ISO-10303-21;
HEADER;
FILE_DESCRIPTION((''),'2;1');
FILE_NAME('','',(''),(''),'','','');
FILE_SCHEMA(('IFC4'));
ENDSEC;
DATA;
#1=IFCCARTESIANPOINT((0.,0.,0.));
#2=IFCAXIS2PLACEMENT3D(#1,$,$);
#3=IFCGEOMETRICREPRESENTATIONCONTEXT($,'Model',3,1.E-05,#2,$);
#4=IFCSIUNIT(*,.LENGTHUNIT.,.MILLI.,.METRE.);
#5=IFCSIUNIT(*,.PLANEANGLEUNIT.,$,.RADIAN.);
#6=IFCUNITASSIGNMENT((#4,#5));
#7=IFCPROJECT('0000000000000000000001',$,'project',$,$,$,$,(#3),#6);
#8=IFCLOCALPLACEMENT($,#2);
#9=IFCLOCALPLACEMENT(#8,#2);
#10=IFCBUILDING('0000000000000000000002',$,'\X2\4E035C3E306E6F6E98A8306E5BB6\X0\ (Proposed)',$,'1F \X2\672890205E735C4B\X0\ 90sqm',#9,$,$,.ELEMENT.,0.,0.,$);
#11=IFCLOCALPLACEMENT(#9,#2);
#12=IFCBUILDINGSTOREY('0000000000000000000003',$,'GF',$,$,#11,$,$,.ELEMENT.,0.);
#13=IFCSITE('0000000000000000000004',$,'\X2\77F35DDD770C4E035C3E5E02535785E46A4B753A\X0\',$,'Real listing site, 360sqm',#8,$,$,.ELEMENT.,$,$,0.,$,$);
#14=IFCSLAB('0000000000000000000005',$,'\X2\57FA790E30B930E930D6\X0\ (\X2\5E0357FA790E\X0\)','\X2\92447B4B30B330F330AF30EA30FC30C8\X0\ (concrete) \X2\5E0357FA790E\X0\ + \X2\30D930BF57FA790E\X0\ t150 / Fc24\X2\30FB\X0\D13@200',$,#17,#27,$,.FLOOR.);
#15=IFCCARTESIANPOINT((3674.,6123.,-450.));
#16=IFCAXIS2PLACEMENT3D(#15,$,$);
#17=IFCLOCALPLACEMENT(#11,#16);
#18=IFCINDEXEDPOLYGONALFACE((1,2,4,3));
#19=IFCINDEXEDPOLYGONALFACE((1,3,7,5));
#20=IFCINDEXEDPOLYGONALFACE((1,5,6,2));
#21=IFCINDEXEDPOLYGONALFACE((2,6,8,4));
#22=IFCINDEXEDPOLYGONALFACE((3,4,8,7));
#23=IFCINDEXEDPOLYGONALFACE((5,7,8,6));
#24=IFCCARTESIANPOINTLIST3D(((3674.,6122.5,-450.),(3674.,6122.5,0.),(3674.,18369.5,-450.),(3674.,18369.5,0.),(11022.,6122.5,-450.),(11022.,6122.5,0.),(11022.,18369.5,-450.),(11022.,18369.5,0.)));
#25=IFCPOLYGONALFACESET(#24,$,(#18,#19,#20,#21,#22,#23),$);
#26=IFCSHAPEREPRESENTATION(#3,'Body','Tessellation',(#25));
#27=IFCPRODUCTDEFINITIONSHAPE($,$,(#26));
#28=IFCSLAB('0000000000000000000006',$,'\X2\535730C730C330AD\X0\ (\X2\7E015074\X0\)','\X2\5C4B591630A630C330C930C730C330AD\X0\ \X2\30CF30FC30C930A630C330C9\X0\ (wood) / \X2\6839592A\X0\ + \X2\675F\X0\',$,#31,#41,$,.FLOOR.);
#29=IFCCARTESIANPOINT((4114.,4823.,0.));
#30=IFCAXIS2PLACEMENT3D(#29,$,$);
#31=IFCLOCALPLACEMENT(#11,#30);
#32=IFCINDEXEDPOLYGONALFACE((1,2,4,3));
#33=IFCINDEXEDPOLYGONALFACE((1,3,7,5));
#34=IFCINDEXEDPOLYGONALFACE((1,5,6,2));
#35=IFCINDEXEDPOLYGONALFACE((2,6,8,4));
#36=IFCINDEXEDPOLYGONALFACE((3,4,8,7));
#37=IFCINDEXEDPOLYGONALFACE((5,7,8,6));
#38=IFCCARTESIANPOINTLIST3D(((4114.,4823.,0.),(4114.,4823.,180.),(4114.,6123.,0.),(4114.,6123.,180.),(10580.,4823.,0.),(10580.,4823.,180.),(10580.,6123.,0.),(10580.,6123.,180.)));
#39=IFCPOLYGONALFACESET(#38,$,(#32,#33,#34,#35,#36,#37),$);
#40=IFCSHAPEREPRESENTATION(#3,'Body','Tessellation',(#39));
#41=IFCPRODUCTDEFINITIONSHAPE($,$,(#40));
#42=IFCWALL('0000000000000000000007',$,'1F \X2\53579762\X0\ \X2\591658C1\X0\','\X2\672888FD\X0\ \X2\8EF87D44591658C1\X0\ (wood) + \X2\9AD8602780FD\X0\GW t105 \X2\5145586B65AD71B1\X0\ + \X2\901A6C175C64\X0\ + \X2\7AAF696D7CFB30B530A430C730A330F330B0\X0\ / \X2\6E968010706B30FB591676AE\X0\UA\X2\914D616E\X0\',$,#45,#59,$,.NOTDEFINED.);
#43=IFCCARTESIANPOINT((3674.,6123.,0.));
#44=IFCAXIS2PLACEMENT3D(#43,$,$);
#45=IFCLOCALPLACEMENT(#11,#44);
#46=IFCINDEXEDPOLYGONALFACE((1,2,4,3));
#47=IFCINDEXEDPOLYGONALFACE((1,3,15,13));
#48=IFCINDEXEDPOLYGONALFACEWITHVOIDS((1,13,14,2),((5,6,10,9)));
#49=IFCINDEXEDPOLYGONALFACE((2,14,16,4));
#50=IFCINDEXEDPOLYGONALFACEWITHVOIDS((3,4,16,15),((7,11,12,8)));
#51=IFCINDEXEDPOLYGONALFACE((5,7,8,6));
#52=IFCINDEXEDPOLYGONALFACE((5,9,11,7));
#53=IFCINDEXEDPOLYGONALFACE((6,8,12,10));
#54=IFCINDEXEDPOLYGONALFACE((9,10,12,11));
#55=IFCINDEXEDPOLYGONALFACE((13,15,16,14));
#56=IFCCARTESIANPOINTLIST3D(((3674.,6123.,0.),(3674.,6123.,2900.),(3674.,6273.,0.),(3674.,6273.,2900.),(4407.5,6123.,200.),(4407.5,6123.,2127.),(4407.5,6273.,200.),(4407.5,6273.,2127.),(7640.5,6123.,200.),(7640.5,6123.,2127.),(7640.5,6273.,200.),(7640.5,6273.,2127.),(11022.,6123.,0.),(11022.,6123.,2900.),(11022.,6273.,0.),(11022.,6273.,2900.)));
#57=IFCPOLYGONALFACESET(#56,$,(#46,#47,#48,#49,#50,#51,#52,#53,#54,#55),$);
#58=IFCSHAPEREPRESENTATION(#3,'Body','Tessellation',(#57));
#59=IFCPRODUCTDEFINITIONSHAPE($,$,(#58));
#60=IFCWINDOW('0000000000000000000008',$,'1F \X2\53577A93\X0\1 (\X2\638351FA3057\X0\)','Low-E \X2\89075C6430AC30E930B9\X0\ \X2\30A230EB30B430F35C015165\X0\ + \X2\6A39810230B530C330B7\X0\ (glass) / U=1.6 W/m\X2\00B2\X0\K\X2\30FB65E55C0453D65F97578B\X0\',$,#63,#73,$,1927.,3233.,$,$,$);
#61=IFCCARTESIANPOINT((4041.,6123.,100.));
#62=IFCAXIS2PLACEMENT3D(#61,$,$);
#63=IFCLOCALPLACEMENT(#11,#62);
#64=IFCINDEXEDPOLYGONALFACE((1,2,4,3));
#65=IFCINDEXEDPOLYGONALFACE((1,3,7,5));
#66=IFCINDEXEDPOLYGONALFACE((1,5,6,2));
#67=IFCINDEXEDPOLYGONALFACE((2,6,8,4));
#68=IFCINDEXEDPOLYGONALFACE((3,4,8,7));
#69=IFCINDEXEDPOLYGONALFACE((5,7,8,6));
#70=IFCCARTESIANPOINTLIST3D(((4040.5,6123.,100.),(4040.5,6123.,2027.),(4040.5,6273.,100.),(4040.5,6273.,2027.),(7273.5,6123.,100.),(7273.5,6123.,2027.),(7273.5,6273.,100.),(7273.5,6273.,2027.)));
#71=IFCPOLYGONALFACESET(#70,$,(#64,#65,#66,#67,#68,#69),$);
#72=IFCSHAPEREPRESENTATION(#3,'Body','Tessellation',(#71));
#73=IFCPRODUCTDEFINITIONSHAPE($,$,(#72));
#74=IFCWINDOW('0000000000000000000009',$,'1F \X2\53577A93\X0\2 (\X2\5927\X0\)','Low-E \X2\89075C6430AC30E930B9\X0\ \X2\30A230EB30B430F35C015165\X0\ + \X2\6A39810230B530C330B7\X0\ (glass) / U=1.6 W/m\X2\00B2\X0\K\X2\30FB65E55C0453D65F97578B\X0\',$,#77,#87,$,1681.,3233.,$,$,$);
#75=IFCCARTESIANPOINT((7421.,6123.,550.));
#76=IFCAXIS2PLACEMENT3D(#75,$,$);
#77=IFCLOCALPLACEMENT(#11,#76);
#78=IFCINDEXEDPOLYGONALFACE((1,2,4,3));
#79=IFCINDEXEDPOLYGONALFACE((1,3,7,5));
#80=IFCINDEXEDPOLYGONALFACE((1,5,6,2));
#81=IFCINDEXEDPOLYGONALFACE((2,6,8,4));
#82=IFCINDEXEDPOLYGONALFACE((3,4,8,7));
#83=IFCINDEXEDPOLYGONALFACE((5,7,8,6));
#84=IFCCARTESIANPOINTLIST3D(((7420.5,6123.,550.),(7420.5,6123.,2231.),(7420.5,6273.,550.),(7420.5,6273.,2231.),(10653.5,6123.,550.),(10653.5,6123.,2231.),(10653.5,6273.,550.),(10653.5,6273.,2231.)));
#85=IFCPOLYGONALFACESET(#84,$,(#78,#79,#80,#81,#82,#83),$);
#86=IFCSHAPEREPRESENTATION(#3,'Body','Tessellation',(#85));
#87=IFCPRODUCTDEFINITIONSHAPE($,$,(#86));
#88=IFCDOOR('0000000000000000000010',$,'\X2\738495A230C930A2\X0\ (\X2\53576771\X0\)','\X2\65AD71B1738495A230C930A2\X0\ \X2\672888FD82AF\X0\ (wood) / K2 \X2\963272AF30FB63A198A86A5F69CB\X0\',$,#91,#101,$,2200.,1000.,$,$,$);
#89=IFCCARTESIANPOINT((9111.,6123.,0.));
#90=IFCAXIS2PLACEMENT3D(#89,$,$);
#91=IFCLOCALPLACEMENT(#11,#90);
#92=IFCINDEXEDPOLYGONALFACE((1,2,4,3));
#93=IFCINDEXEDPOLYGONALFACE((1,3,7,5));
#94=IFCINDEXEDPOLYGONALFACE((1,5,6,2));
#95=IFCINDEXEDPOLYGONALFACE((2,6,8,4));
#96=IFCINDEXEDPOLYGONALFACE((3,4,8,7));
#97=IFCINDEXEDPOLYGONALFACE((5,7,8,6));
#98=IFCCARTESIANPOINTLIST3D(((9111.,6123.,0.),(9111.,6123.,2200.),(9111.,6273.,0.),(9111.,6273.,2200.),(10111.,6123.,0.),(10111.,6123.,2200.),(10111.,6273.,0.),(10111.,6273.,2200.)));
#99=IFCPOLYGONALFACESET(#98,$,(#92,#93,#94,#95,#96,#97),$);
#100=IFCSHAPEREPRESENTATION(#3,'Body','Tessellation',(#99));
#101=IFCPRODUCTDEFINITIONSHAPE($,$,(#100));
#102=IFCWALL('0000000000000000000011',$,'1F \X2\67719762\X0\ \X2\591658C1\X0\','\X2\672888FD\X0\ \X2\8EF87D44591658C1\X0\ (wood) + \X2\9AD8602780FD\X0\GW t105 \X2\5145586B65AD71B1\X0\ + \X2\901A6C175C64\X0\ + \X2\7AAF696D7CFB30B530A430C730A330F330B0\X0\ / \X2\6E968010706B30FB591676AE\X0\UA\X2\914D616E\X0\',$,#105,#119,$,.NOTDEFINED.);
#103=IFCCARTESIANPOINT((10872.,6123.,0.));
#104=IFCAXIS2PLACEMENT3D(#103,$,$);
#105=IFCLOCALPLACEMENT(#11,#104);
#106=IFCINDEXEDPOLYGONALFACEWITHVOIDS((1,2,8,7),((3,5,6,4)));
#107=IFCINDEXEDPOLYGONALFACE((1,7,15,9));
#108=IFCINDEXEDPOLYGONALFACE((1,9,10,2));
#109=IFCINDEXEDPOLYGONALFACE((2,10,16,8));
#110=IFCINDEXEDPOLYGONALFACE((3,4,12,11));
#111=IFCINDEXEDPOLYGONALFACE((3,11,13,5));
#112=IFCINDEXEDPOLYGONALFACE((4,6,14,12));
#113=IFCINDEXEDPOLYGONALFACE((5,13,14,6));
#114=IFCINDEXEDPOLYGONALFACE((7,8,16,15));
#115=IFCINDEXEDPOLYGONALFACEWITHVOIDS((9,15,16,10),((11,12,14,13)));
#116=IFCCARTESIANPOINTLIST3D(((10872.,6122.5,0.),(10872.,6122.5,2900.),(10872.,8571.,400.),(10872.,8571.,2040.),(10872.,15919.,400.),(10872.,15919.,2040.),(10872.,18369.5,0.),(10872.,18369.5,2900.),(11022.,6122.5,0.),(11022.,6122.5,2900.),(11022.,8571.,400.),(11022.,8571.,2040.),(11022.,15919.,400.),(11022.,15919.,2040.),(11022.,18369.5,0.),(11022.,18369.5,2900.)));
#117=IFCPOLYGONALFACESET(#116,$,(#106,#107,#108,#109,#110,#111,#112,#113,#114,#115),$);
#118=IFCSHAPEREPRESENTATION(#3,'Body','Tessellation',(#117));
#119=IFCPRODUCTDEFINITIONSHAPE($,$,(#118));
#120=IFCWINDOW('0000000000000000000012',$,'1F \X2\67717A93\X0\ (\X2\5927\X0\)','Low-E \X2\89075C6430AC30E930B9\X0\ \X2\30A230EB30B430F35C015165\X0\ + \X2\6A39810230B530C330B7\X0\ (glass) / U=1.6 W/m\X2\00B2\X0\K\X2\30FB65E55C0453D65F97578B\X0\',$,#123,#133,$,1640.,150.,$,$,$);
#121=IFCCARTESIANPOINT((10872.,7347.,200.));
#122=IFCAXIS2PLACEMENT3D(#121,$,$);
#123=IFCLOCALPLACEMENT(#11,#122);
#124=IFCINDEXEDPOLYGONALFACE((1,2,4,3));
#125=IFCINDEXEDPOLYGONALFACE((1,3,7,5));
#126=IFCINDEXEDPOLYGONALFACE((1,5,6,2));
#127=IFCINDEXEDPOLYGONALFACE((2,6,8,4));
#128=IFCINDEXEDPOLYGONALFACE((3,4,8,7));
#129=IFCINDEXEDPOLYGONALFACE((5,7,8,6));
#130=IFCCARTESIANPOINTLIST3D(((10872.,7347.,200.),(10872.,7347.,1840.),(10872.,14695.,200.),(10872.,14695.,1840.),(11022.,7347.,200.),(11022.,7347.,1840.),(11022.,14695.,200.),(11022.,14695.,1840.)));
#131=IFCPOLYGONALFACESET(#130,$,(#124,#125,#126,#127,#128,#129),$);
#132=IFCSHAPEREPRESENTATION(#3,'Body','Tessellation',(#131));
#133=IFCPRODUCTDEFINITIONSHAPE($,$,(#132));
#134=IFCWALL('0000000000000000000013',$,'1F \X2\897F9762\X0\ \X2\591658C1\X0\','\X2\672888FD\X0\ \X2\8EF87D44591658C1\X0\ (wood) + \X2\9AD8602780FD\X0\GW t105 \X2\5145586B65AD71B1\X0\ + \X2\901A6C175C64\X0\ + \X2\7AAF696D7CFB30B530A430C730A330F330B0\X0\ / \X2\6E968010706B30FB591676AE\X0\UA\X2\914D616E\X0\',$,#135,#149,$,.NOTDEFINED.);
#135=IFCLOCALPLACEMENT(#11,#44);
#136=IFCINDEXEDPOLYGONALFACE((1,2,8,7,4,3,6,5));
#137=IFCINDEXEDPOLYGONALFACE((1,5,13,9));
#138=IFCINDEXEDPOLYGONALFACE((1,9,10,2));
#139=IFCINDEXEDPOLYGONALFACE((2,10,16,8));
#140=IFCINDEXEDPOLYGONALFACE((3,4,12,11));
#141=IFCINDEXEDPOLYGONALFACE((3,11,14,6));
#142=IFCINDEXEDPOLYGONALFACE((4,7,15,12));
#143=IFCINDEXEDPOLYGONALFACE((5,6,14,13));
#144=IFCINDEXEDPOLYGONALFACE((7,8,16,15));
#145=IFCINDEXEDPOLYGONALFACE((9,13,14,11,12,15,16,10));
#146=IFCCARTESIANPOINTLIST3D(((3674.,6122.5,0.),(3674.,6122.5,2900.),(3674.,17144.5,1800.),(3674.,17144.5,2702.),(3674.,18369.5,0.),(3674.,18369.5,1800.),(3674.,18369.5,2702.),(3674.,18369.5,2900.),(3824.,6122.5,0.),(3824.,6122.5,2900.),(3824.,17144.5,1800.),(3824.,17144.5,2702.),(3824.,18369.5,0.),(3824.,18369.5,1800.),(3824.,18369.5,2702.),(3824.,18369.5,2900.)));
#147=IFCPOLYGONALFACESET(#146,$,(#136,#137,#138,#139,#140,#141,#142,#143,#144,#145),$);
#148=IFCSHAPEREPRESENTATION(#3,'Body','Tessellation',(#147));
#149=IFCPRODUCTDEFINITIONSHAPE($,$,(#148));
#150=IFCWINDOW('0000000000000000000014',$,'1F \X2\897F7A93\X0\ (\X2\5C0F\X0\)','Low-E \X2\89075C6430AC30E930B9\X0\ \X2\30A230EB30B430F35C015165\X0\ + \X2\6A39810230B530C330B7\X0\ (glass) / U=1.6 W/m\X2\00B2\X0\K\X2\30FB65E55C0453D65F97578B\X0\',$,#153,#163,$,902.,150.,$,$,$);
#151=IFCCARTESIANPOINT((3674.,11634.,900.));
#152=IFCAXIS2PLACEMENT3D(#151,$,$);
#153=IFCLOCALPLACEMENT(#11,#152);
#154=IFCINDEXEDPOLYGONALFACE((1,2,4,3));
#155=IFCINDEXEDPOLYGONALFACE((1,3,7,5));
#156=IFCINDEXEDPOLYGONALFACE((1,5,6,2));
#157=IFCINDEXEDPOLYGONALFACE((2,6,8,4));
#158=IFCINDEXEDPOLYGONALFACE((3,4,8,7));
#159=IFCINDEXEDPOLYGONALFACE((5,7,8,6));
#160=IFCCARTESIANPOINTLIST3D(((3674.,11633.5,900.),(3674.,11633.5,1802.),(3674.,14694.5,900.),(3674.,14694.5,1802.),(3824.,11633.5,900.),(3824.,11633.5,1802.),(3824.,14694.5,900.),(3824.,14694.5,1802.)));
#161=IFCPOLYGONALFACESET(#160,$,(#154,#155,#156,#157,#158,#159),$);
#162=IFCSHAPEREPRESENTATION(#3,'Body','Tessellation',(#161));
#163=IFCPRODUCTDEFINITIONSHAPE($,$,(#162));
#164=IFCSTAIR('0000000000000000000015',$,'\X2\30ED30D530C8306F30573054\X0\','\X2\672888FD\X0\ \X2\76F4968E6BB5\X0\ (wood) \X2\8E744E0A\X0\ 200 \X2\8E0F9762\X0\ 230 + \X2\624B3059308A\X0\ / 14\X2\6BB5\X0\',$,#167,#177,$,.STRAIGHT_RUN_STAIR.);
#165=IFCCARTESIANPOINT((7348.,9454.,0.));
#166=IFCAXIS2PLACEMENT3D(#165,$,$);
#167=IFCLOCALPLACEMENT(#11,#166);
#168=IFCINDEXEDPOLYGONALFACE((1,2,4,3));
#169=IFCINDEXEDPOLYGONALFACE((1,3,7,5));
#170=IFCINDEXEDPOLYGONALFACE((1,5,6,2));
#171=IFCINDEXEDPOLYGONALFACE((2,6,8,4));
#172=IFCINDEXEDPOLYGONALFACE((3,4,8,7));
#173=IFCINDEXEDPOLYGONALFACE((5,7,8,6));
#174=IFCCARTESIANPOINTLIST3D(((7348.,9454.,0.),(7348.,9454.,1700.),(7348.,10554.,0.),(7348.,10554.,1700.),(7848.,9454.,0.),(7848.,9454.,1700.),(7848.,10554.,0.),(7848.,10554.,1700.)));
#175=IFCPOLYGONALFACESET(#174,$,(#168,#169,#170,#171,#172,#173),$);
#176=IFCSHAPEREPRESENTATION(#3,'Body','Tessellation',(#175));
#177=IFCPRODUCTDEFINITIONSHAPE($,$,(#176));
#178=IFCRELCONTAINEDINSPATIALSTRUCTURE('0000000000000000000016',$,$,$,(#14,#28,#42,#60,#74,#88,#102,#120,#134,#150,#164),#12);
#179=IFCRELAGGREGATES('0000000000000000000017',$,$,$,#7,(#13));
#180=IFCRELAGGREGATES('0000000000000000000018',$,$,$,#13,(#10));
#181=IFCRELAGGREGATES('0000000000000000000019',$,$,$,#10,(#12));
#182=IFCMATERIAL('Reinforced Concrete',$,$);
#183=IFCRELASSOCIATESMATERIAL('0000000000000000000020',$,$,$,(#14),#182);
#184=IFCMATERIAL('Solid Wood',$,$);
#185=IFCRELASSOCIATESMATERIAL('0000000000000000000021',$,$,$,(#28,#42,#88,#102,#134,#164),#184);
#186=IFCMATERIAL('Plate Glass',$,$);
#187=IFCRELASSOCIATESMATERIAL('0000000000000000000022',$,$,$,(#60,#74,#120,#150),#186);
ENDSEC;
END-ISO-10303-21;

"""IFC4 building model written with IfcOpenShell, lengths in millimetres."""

from ifc_helpers import new_model, si_unit, frame, frame_2d, origin, place, context, project, spatial, rectangle, extrude, material, element, fill, save


model = new_model("IFC4")

# Units and contexts
model_context = context("Model", 3, precision=1e-05, world=origin())
ifc_project = project(units=[si_unit("LENGTHUNIT", "METRE", prefix="MILLI"), si_unit("PLANEANGLEUNIT", "RADIAN")], contexts=[model_context])

# Site, building, storey
site_placement = place(None, origin())
site = spatial("IfcSite", under=ifc_project, at=site_placement, Name="石川県七尾市南藤橋町", ObjectType="Real listing site, 360sqm", CompositionType="ELEMENT", RefElevation=0.0)
building_placement = place(site_placement, origin())
building = spatial("IfcBuilding", under=site, at=building_placement, Name="七尾の潮風の家 (Proposed)", ObjectType="1F 木造平屋 90sqm", CompositionType="ELEMENT", ElevationOfRefHeight=0.0, ElevationOfTerrain=0.0)
storey_placement = place(building_placement, origin())
storey = spatial("IfcBuildingStorey", under=building, at=storey_placement, Name="GF", CompositionType="ELEMENT", Elevation=0.0)

# Slabs
ifc_material_1 = material(Name="Reinforced Concrete")
slab_1_placement = place(storey_placement, frame((3674.0, 6123.0, -450.0)))
element("IfcSlab", 1, at=slab_1_placement, inside=storey, material=ifc_material_1, Name="基礎スラブ (布基礎)", Description="鉄筋コンクリート (concrete) 布基礎 + ベタ基礎 t150 / Fc24・D13@200", PredefinedType="FLOOR", context=model_context, shape_type="SweptSolid", body=[
    extrude(rectangle(XDim=7348.0, YDim=12247.0, at=frame_2d((3674.0, 6123.0))), frame((3674.0, 6123.0, -450.0)), (0.0, 0.0, 1.0), 450.0),
])
ifc_material_2 = material(Name="Solid Wood")
slab_2_placement = place(storey_placement, frame((4114.0, 4823.0, 0.0)))
element("IfcSlab", 2, at=slab_2_placement, inside=storey, material=ifc_material_2, Name="南デッキ (縁側)", Description="屋外ウッドデッキ ハードウッド (wood) / 根太 + 束", PredefinedType="FLOOR", context=model_context, shape_type="SweptSolid", body=[
    extrude(rectangle(XDim=6466.0, YDim=1300.0, at=frame_2d((3233.0, 650.0))), frame((4114.0, 4823.0, 0.0)), (0.0, 0.0, 1.0), 180.0),
])

# Wall, openings, windows, door
wall_1_placement = place(storey_placement, frame((3674.0, 6123.0, 0.0)))
wall_1 = element("IfcWall", 3, at=wall_1_placement, inside=storey, material=ifc_material_2, Name="1F 南面 外壁", Description="木製 軸組外壁 (wood) + 高性能GW t105 充填断熱 + 通気層 + 窯業系サイディング / 準耐火・外皮UA配慮", PredefinedType="NOTDEFINED", context=model_context, shape_type="SweptSolid", body=[
    extrude(rectangle(XDim=7348.0, YDim=150.0, at=frame_2d((3674.0, 75.0))), frame((3674.0, 6123.0, 0.0)), (0.0, 0.0, 1.0), 2900.0),
])
opening_1_placement = place(storey_placement, frame((4041.0, 6123.0, 100.0)))
opening_1 = element("IfcOpeningElement", 4, at=opening_1_placement, cuts=wall_1, PredefinedType="NOTDEFINED", context=model_context, shape_type="SweptSolid", body=[
    extrude(rectangle(XDim=3233.0, YDim=150.0, at=frame_2d((1616.0, 75.0))), frame((4041.0, 6123.0, 100.0)), (0.0, 0.0, 1.0), 1927.0),
])
opening_2_placement = place(storey_placement, frame((7421.0, 6123.0, 550.0)))
opening_2 = element("IfcOpeningElement", 5, at=opening_2_placement, cuts=wall_1, PredefinedType="NOTDEFINED", context=model_context, shape_type="SweptSolid", body=[
    extrude(rectangle(XDim=3233.0, YDim=150.0, at=frame_2d((1616.0, 75.0))), frame((7421.0, 6123.0, 550.0)), (0.0, 0.0, 1.0), 1681.0),
])
opening_3_placement = place(storey_placement, frame((9111.0, 6123.0, 0.0)))
opening_3 = element("IfcOpeningElement", 6, at=opening_3_placement, cuts=wall_1, PredefinedType="NOTDEFINED", context=model_context, shape_type="SweptSolid", body=[
    extrude(rectangle(XDim=1000.0, YDim=150.0, at=frame_2d((500.0, 75.0))), frame((9111.0, 6123.0, 0.0)), (0.0, 0.0, 1.0), 2200.0),
])
ifc_material_3 = material(Name="Plate Glass")
window_1_placement = place(storey_placement, frame((4041.0, 6123.0, 100.0)))
window_1 = element("IfcWindow", 7, at=window_1_placement, inside=storey, material=ifc_material_3, Name="1F 南窓1 (掃出し)", Description="Low-E 複層ガラス アルゴン封入 + 樹脂サッシ (glass) / U=1.6 W/m²K・日射取得型", OverallHeight=1927.0, OverallWidth=3233.0, context=model_context, shape_type="SweptSolid", body=[
    extrude(rectangle(XDim=3233.0, YDim=150.0, at=frame_2d((1616.0, 75.0))), frame((4041.0, 6123.0, 100.0)), (0.0, 0.0, 1.0), 1927.0),
])
fill(opening_1, window_1)
window_2_placement = place(storey_placement, frame((7421.0, 6123.0, 550.0)))
window_2 = element("IfcWindow", 8, at=window_2_placement, inside=storey, material=ifc_material_3, Name="1F 南窓2 (大)", Description="Low-E 複層ガラス アルゴン封入 + 樹脂サッシ (glass) / U=1.6 W/m²K・日射取得型", OverallHeight=1681.0, OverallWidth=3233.0, context=model_context, shape_type="SweptSolid", body=[
    extrude(rectangle(XDim=3233.0, YDim=150.0, at=frame_2d((1616.0, 75.0))), frame((7421.0, 6123.0, 550.0)), (0.0, 0.0, 1.0), 1681.0),
])
fill(opening_2, window_2)
door_placement = place(storey_placement, frame((9111.0, 6123.0, 0.0)))
door = element("IfcDoor", 9, at=door_placement, inside=storey, material=ifc_material_2, Name="玄関ドア (南東)", Description="断熱玄関ドア 木製芯 (wood) / K2 防犯・採風機構", OverallHeight=2200.0, OverallWidth=1000.0, context=model_context, shape_type="SweptSolid", body=[
    extrude(rectangle(XDim=1000.0, YDim=150.0, at=frame_2d((500.0, 75.0))), frame((9111.0, 6123.0, 0.0)), (0.0, 0.0, 1.0), 2200.0),
])
fill(opening_3, door)

# Walls, openings, windows
wall_2_placement = place(storey_placement, frame((10872.0, 6123.0, 0.0)))
wall_2 = element("IfcWall", 10, at=wall_2_placement, inside=storey, material=ifc_material_2, Name="1F 東面 外壁", Description="木製 軸組外壁 (wood) + 高性能GW t105 充填断熱 + 通気層 + 窯業系サイディング / 準耐火・外皮UA配慮", PredefinedType="NOTDEFINED", context=model_context, shape_type="SweptSolid", body=[
    extrude(rectangle(XDim=150.0, YDim=12247.0, at=frame_2d((75.0, 6123.0))), frame((10872.0, 6123.0, 0.0)), (0.0, 0.0, 1.0), 2900.0),
])
opening_4_placement = place(storey_placement, frame((10872.0, 7347.0, 200.0)))
opening_4 = element("IfcOpeningElement", 11, at=opening_4_placement, cuts=wall_2, PredefinedType="NOTDEFINED", context=model_context, shape_type="SweptSolid", body=[
    extrude(rectangle(XDim=150.0, YDim=7348.0, at=frame_2d((75.0, 3674.0))), frame((10872.0, 7347.0, 200.0)), (0.0, 0.0, 1.0), 1640.0),
])
window_3_placement = place(storey_placement, frame((10872.0, 7347.0, 200.0)))
window_3 = element("IfcWindow", 12, at=window_3_placement, inside=storey, material=ifc_material_3, Name="1F 東窓 (大)", Description="Low-E 複層ガラス アルゴン封入 + 樹脂サッシ (glass) / U=1.6 W/m²K・日射取得型", OverallHeight=1640.0, OverallWidth=150.0, context=model_context, shape_type="SweptSolid", body=[
    extrude(rectangle(XDim=150.0, YDim=7348.0, at=frame_2d((75.0, 3674.0))), frame((10872.0, 7347.0, 200.0)), (0.0, 0.0, 1.0), 1640.0),
])
fill(opening_4, window_3)
wall_3_placement = place(storey_placement, frame((3674.0, 6123.0, 0.0)))
wall_3 = element("IfcWall", 13, at=wall_3_placement, inside=storey, material=ifc_material_2, Name="1F 西面 外壁", Description="木製 軸組外壁 (wood) + 高性能GW t105 充填断熱 + 通気層 + 窯業系サイディング / 準耐火・外皮UA配慮", PredefinedType="NOTDEFINED", context=model_context, shape_type="SweptSolid", body=[
    extrude(rectangle(XDim=150.0, YDim=12247.0, at=frame_2d((75.0, 6123.0))), frame((3674.0, 6123.0, 0.0)), (0.0, 0.0, 1.0), 2900.0),
])
opening_5_placement = place(storey_placement, frame((3674.0, 11634.0, 900.0)))
opening_5 = element("IfcOpeningElement", 14, at=opening_5_placement, cuts=wall_3, PredefinedType="NOTDEFINED", context=model_context, shape_type="SweptSolid", body=[
    extrude(rectangle(XDim=150.0, YDim=3061.0, at=frame_2d((75.0, 1530.0))), frame((3674.0, 11634.0, 900.0)), (0.0, 0.0, 1.0), 902.0),
])
window_4_placement = place(storey_placement, frame((3674.0, 11634.0, 900.0)))
window_4 = element("IfcWindow", 15, at=window_4_placement, inside=storey, material=ifc_material_3, Name="1F 西窓 (小)", Description="Low-E 複層ガラス アルゴン封入 + 樹脂サッシ (glass) / U=1.6 W/m²K・日射取得型", OverallHeight=902.0, OverallWidth=150.0, context=model_context, shape_type="SweptSolid", body=[
    extrude(rectangle(XDim=150.0, YDim=3061.0, at=frame_2d((75.0, 1530.0))), frame((3674.0, 11634.0, 900.0)), (0.0, 0.0, 1.0), 902.0),
])
fill(opening_5, window_4)

# Stair
stair_placement = place(storey_placement, frame((7348.0, 9454.0, 0.0)))
element("IfcStair", 16, at=stair_placement, inside=storey, material=ifc_material_2, Name="ロフトはしご", Description="木製 直階段 (wood) 蹴上 200 踏面 230 + 手すり / 14段", PredefinedType="STRAIGHT_RUN_STAIR", context=model_context, shape_type="SweptSolid", body=[
    extrude(rectangle(XDim=500.0, YDim=1100.0, at=frame_2d((250.0, 550.0))), frame((7348.0, 9454.0, 0.0)), (0.0, 0.0, 1.0), 1700.0),
])

save(model, "model.ifc")
